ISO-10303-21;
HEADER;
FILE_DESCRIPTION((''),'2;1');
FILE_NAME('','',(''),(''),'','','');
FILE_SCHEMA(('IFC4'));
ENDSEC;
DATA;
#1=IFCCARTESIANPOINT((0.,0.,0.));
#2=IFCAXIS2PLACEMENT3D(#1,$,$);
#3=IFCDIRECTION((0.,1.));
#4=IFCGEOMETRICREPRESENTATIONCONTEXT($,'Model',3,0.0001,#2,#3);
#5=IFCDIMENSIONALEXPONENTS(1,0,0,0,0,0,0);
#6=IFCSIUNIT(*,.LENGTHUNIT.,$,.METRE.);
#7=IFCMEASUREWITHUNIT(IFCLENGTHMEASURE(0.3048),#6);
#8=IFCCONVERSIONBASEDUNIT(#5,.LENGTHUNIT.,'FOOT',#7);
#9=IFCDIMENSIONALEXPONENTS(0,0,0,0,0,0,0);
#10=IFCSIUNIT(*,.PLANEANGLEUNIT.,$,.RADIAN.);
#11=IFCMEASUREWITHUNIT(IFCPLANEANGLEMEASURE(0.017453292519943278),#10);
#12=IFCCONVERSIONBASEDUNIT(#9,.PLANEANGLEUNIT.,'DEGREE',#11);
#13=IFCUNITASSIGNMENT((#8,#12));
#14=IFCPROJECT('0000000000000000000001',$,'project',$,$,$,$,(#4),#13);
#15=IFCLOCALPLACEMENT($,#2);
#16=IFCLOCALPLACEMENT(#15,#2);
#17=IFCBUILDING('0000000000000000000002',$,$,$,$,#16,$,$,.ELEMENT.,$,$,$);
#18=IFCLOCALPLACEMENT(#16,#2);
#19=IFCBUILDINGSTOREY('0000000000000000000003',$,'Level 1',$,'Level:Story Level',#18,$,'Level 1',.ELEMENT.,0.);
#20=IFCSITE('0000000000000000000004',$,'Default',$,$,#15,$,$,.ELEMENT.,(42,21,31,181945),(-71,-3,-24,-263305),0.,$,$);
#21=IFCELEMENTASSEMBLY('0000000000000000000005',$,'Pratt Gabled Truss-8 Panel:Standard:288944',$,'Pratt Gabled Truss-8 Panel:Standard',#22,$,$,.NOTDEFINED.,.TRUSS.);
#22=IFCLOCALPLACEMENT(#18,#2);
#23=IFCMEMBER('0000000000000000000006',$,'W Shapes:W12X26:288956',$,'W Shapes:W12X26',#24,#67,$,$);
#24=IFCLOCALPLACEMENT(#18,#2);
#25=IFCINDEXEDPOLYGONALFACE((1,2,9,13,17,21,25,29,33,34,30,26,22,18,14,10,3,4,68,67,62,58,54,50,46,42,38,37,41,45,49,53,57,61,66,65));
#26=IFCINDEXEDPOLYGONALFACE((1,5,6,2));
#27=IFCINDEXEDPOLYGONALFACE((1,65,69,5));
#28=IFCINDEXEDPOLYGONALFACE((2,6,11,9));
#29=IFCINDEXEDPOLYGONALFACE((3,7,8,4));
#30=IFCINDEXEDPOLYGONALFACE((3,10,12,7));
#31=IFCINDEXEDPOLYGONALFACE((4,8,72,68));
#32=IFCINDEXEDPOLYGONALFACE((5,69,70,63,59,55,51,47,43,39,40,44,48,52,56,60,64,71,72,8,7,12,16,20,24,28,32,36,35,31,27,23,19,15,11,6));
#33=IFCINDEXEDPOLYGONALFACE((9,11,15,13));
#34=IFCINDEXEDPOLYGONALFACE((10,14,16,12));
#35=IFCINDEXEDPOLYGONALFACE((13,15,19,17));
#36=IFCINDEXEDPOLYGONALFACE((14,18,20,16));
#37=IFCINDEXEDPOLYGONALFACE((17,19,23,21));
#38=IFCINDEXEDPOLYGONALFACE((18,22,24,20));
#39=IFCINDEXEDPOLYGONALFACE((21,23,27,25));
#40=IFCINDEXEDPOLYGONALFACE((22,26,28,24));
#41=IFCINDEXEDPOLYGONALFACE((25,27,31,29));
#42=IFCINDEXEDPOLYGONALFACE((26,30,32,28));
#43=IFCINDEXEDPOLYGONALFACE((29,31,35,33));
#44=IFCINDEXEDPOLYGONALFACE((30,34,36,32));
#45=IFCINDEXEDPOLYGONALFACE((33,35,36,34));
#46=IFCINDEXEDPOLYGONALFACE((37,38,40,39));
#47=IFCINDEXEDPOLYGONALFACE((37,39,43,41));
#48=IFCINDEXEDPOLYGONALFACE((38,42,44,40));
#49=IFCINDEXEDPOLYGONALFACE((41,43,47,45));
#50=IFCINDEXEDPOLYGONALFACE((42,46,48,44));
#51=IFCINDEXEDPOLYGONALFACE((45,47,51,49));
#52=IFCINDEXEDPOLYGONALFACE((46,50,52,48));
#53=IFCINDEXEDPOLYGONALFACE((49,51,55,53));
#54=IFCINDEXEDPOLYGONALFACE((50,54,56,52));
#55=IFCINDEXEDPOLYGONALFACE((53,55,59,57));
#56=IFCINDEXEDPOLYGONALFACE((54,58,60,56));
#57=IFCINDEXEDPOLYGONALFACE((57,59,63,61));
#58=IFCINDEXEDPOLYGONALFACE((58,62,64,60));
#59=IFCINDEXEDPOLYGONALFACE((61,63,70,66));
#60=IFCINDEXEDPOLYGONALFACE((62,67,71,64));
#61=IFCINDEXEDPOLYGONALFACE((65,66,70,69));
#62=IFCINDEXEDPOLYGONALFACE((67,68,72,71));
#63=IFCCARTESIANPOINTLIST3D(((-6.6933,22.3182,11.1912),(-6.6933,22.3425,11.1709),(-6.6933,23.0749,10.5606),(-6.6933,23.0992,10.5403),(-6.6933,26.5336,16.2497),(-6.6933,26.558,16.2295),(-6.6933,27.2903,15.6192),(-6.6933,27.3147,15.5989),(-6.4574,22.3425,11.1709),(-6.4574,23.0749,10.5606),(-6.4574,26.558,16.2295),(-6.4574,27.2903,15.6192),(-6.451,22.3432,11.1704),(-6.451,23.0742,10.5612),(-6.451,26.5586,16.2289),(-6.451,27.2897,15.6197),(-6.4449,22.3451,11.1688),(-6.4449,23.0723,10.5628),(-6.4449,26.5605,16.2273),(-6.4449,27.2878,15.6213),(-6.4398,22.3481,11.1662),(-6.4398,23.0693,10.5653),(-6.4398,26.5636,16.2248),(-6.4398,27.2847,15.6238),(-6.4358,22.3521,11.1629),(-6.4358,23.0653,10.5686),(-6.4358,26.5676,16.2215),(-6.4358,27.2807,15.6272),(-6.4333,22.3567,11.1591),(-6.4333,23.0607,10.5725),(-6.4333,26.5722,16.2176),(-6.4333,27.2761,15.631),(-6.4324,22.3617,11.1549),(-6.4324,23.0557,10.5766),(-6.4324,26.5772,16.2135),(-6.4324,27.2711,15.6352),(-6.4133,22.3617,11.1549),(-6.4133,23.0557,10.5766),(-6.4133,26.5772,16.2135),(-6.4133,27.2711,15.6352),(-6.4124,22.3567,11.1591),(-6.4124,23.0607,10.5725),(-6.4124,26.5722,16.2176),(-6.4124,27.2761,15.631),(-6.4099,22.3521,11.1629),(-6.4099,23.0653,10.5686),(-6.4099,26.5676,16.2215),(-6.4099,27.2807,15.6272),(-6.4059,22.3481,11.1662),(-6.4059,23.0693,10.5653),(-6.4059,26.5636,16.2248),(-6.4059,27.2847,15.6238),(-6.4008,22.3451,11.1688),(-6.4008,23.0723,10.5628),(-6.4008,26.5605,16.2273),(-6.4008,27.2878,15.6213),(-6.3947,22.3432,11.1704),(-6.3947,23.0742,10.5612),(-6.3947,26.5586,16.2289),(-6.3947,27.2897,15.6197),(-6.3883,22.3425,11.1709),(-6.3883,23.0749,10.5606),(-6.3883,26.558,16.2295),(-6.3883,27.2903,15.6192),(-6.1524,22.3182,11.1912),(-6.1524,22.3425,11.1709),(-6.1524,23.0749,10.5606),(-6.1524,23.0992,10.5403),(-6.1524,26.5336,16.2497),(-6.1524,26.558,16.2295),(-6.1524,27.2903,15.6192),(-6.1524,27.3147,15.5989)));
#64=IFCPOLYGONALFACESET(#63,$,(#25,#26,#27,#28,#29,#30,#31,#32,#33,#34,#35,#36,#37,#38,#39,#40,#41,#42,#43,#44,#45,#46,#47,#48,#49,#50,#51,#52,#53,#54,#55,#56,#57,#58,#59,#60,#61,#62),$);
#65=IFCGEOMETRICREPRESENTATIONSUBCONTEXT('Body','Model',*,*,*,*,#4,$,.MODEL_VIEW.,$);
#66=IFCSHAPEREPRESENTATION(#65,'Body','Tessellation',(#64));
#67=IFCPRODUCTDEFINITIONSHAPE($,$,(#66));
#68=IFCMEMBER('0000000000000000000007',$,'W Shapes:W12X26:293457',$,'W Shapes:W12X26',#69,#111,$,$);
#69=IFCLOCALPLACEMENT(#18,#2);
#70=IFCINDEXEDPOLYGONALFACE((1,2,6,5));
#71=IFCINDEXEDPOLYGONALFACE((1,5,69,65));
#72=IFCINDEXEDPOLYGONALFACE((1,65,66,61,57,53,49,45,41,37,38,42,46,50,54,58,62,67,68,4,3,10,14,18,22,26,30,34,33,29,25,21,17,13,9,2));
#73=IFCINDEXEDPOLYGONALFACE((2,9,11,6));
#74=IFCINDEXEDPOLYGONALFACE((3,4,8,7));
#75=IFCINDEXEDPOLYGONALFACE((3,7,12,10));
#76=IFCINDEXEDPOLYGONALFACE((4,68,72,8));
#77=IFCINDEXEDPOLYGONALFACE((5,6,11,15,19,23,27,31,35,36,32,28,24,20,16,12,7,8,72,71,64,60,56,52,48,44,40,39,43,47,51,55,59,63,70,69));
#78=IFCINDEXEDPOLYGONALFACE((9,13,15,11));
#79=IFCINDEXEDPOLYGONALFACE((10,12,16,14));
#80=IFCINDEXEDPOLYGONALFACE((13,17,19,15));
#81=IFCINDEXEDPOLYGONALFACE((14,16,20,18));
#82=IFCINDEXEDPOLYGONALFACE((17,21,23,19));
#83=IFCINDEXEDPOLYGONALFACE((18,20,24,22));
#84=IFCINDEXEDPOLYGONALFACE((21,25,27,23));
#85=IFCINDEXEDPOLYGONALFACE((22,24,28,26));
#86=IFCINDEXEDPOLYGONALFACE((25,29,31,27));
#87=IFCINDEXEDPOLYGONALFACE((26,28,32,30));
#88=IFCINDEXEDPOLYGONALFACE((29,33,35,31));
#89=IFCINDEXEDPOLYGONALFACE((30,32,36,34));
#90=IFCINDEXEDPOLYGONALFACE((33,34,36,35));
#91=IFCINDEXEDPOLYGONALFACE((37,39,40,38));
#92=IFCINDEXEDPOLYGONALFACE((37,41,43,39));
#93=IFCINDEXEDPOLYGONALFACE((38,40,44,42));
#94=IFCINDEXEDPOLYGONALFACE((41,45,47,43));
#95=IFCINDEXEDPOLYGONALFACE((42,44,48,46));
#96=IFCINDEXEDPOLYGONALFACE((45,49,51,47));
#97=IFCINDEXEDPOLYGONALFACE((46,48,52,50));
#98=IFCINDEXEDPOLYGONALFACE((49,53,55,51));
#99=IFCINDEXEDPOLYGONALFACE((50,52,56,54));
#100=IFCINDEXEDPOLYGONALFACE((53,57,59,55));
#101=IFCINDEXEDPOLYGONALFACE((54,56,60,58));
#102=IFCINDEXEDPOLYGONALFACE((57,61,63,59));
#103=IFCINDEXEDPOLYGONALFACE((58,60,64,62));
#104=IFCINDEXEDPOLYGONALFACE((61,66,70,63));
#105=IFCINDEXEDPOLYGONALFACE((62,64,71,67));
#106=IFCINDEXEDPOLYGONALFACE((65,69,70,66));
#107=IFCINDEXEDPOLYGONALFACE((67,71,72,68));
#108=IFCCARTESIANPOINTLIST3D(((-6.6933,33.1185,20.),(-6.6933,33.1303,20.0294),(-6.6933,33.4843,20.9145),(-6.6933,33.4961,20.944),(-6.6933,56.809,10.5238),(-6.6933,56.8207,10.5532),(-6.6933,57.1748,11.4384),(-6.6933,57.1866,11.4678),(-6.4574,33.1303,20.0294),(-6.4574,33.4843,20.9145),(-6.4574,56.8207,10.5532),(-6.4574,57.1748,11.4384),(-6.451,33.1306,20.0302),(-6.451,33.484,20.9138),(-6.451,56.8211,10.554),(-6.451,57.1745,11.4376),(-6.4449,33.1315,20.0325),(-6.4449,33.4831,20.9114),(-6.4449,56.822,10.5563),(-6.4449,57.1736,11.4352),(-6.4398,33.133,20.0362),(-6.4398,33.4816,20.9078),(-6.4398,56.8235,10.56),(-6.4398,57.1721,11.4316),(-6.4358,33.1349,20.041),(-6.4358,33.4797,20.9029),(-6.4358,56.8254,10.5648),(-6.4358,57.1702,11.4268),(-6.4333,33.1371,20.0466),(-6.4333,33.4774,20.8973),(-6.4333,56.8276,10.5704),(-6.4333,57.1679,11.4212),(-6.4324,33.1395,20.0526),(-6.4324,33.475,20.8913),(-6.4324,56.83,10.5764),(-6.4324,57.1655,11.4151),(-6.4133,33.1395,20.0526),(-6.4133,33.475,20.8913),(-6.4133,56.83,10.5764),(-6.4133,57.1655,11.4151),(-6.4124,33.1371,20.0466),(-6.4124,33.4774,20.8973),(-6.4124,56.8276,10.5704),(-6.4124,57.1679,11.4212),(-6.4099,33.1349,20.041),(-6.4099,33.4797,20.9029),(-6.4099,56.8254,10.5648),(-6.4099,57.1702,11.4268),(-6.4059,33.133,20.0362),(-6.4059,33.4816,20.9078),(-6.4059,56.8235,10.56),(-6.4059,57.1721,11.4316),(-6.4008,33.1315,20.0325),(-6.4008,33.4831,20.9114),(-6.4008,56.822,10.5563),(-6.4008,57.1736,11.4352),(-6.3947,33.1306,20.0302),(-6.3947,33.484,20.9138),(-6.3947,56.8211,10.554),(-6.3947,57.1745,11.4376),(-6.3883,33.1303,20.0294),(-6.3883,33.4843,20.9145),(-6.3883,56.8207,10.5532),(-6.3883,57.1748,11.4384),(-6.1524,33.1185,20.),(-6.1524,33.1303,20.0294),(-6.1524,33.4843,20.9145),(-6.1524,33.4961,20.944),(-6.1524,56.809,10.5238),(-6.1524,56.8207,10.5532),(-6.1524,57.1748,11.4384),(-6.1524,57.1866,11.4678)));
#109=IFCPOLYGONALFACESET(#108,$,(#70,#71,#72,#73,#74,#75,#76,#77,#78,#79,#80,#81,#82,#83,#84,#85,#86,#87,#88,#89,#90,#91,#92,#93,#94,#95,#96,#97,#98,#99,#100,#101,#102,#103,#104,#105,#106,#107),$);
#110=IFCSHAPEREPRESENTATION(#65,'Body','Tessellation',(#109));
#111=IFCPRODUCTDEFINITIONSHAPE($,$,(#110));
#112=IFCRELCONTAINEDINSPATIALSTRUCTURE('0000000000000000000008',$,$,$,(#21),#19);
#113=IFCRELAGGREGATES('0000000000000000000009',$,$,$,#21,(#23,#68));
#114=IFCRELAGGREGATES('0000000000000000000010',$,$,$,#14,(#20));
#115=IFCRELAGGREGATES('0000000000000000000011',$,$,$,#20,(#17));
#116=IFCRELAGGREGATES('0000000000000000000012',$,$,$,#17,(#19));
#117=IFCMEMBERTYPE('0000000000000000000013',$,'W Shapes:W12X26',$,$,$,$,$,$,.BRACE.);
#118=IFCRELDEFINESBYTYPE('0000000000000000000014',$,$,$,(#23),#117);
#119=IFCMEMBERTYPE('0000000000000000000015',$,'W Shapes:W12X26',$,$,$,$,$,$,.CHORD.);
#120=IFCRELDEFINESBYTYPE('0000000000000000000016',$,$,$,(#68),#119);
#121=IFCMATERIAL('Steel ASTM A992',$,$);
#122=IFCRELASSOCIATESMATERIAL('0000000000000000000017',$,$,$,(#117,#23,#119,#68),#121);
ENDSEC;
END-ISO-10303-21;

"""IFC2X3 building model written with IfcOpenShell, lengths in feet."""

from ifc_helpers import new_model, entity, si_unit, converted_unit, direction, frame, frame_2d, origin, place, context, subcontext, project, spatial, polyline, circle_curve, parameter, trimmed, segment, composite_curve, outline, extrude, source, transform, mapped, material, type_object, type_shapes, element, aggregate, save


model = new_model("IFC2X3")

# Units and contexts
model_context = context("Model", 3, precision=0.0001, world=origin(), true_north=direction((0.0, 1.0)))
body_context = subcontext(model_context, "Body", "Model", "MODEL_VIEW")
ifc_project = project(units=[converted_unit("LENGTHUNIT", "FOOT", entity("IfcLengthMeasure", 0.3048), si_unit("LENGTHUNIT", "METRE"), dimensions=[1, 0, 0, 0, 0, 0, 0]), converted_unit("PLANEANGLEUNIT", "DEGREE", entity("IfcPlaneAngleMeasure", 0.017453292519943278), si_unit("PLANEANGLEUNIT", "RADIAN"), dimensions=[0, 0, 0, 0, 0, 0, 0])], contexts=[model_context])

# Site, building, storey
site_placement = place(None, origin())
site = spatial("IfcSite", under=ifc_project, at=site_placement, Name="Default", CompositionType="ELEMENT", RefLatitude=(42, 21, 31, 181945), RefLongitude=(-71, -3, -24, -263305), RefElevation=0.0)
building_placement = place(site_placement, origin())
building = spatial("IfcBuilding", under=site, at=building_placement, CompositionType="ELEMENT")
storey_placement = place(building_placement, origin())
storey = spatial("IfcBuildingStorey", under=building, at=storey_placement, Name="Level 1", ObjectType="Level:Story Level", LongName="Level 1", CompositionType="ELEMENT", Elevation=0.0)

# Element assembly, members
assembly_placement = place(storey_placement, origin())
assembly = element("IfcElementAssembly", 1, at=assembly_placement, inside=storey, Name="Pratt Gabled Truss-8 Panel:Standard:288944", ObjectType="Pratt Gabled Truss-8 Panel:Standard", AssemblyPlace="NOTDEFINED", PredefinedType="TRUSS")
ifc_material = material(Name="Steel ASTM A992")
member_type_1 = type_object("IfcMemberType", Name="W Shapes:W12X26", PredefinedType="BRACE", material=ifc_material)
shared_shape_1 = source(origin(), body_context, "Body", "SweptSolid", [
    extrude(outline(composite_curve([segment(polyline([(-0.2704, -0.4767), (-0.2704, -0.5083)]), True, "CONTINUOUS"), segment(polyline([(-0.2704, -0.5083), (0.2704, -0.5083)]), True, "CONTINUOUS"), segment(polyline([(0.2704, -0.5083), (0.2704, -0.4767)]), True, "CONTINUOUS"), segment(polyline([(0.2704, -0.4767), (0.0346, -0.4767)]), True, "CONTINUOUS"), segment(trimmed(circle_curve(frame_2d((0.0346, -0.4517), x_axis=(1.0, 0.0)), 0.025), [parameter(180.0)], [parameter(270.0)], True, "PARAMETER"), False, "CONTINUOUS"), segment(polyline([(0.0096, -0.4517), (0.0096, 0.4517)]), True, "CONTINUOUS"), segment(trimmed(circle_curve(frame_2d((0.0346, 0.4517), x_axis=(1.0, 0.0)), 0.025), [parameter(90.0)], [parameter(180.0)], True, "PARAMETER"), False, "CONTINUOUS"), segment(polyline([(0.0346, 0.4767), (0.2704, 0.4767)]), True, "CONTINUOUS"), segment(polyline([(0.2704, 0.4767), (0.2704, 0.5083)]), True, "CONTINUOUS"), segment(polyline([(0.2704, 0.5083), (-0.2704, 0.5083)]), True, "CONTINUOUS"), segment(polyline([(-0.2704, 0.5083), (-0.2704, 0.4767)]), True, "CONTINUOUS"), segment(polyline([(-0.2704, 0.4767), (-0.0346, 0.4767)]), True, "CONTINUOUS"), segment(trimmed(circle_curve(frame_2d((-0.0346, 0.4517), x_axis=(1.0, 0.0)), 0.025), [parameter(360.0)], [parameter(90.0)], True, "PARAMETER"), False, "CONTINUOUS"), segment(polyline([(-0.0096, 0.4517), (-0.0096, -0.4517)]), True, "CONTINUOUS"), segment(trimmed(circle_curve(frame_2d((-0.0346, -0.4517), x_axis=(1.0, 0.0)), 0.025), [parameter(270.0)], [parameter(360.0)], True, "PARAMETER"), False, "CONTINUOUS"), segment(polyline([(-0.0346, -0.4767), (-0.2704, -0.4767)]), True, "CONTINUOUS")], self_intersect=False)), frame((-3.7544, 0.0, 0.0), z_axis=(-1.0, 0.0, 0.0), x_axis=(0.0, -1.0, 0.0)), (0.0, 0.0, -1.0), 6.5847),
])
type_shapes(member_type_1, [shared_shape_1])
member_1_placement = place(assembly_placement, frame((-6.4228, 25.1122, 13.75), z_axis=(0.0, 0.768221, -0.640184), x_axis=(0.0, 0.640184, 0.768221)))
member_1 = element("IfcMember", 2, at=member_1_placement, type_object=member_type_1, material=ifc_material, Name="W Shapes:W12X26:288956", ObjectType="W Shapes:W12X26", context=body_context, shape_type="MappedRepresentation", body=[
    mapped(shared_shape_1, transform((0.0, 0.0, 0.0), scale=1.0)),
])
member_type_2 = type_object("IfcMemberType", Name="W Shapes:W12X26", PredefinedType="CHORD", material=ifc_material)
shared_shape_2 = source(origin(), body_context, "Body", "SweptSolid", [
    extrude(outline(composite_curve([segment(polyline([(-0.2704, -0.4767), (-0.2704, -0.5083)]), True, "CONTINUOUS"), segment(polyline([(-0.2704, -0.5083), (0.2704, -0.5083)]), True, "CONTINUOUS"), segment(polyline([(0.2704, -0.5083), (0.2704, -0.4767)]), True, "CONTINUOUS"), segment(polyline([(0.2704, -0.4767), (0.0346, -0.4767)]), True, "CONTINUOUS"), segment(trimmed(circle_curve(frame_2d((0.0346, -0.4517), x_axis=(1.0, 0.0)), 0.025), [parameter(180.0)], [parameter(270.0)], True, "PARAMETER"), False, "CONTINUOUS"), segment(polyline([(0.0096, -0.4517), (0.0096, 0.4517)]), True, "CONTINUOUS"), segment(trimmed(circle_curve(frame_2d((0.0346, 0.4517), x_axis=(1.0, 0.0)), 0.025), [parameter(90.0)], [parameter(180.0)], True, "PARAMETER"), False, "CONTINUOUS"), segment(polyline([(0.0346, 0.4767), (0.2704, 0.4767)]), True, "CONTINUOUS"), segment(polyline([(0.2704, 0.4767), (0.2704, 0.5083)]), True, "CONTINUOUS"), segment(polyline([(0.2704, 0.5083), (-0.2704, 0.5083)]), True, "CONTINUOUS"), segment(polyline([(-0.2704, 0.5083), (-0.2704, 0.4767)]), True, "CONTINUOUS"), segment(polyline([(-0.2704, 0.4767), (-0.0346, 0.4767)]), True, "CONTINUOUS"), segment(trimmed(circle_curve(frame_2d((-0.0346, 0.4517), x_axis=(1.0, 0.0)), 0.025), [parameter(360.0)], [parameter(90.0)], True, "PARAMETER"), False, "CONTINUOUS"), segment(polyline([(-0.0096, 0.4517), (-0.0096, -0.4517)]), True, "CONTINUOUS"), segment(trimmed(circle_curve(frame_2d((-0.0346, -0.4517), x_axis=(1.0, 0.0)), 0.025), [parameter(270.0)], [parameter(360.0)], True, "PARAMETER"), False, "CONTINUOUS"), segment(polyline([(-0.0346, -0.4767), (-0.2704, -0.4767)]), True, "CONTINUOUS")], self_intersect=False)), frame((-14.7337, 0.0, 0.0), z_axis=(-1.0, 0.0, 0.0), x_axis=(0.0, -1.0, 0.0)), (0.0, 0.0, -1.0), 25.5154),
])
type_shapes(member_type_2, [shared_shape_2])
member_2_placement = place(assembly_placement, frame((-6.4228, 46.9872, 15.0), z_axis=(0.0, 0.371391, 0.928477), x_axis=(0.0, 0.928477, -0.371391)))
member_2 = element("IfcMember", 3, at=member_2_placement, type_object=member_type_2, material=ifc_material, Name="W Shapes:W12X26:293457", ObjectType="W Shapes:W12X26", context=body_context, shape_type="MappedRepresentation", body=[
    mapped(shared_shape_2, transform((0.0, 0.0, 0.0), scale=1.0)),
])
aggregate(assembly, [member_1, member_2])

save(model, "model.ifc")
